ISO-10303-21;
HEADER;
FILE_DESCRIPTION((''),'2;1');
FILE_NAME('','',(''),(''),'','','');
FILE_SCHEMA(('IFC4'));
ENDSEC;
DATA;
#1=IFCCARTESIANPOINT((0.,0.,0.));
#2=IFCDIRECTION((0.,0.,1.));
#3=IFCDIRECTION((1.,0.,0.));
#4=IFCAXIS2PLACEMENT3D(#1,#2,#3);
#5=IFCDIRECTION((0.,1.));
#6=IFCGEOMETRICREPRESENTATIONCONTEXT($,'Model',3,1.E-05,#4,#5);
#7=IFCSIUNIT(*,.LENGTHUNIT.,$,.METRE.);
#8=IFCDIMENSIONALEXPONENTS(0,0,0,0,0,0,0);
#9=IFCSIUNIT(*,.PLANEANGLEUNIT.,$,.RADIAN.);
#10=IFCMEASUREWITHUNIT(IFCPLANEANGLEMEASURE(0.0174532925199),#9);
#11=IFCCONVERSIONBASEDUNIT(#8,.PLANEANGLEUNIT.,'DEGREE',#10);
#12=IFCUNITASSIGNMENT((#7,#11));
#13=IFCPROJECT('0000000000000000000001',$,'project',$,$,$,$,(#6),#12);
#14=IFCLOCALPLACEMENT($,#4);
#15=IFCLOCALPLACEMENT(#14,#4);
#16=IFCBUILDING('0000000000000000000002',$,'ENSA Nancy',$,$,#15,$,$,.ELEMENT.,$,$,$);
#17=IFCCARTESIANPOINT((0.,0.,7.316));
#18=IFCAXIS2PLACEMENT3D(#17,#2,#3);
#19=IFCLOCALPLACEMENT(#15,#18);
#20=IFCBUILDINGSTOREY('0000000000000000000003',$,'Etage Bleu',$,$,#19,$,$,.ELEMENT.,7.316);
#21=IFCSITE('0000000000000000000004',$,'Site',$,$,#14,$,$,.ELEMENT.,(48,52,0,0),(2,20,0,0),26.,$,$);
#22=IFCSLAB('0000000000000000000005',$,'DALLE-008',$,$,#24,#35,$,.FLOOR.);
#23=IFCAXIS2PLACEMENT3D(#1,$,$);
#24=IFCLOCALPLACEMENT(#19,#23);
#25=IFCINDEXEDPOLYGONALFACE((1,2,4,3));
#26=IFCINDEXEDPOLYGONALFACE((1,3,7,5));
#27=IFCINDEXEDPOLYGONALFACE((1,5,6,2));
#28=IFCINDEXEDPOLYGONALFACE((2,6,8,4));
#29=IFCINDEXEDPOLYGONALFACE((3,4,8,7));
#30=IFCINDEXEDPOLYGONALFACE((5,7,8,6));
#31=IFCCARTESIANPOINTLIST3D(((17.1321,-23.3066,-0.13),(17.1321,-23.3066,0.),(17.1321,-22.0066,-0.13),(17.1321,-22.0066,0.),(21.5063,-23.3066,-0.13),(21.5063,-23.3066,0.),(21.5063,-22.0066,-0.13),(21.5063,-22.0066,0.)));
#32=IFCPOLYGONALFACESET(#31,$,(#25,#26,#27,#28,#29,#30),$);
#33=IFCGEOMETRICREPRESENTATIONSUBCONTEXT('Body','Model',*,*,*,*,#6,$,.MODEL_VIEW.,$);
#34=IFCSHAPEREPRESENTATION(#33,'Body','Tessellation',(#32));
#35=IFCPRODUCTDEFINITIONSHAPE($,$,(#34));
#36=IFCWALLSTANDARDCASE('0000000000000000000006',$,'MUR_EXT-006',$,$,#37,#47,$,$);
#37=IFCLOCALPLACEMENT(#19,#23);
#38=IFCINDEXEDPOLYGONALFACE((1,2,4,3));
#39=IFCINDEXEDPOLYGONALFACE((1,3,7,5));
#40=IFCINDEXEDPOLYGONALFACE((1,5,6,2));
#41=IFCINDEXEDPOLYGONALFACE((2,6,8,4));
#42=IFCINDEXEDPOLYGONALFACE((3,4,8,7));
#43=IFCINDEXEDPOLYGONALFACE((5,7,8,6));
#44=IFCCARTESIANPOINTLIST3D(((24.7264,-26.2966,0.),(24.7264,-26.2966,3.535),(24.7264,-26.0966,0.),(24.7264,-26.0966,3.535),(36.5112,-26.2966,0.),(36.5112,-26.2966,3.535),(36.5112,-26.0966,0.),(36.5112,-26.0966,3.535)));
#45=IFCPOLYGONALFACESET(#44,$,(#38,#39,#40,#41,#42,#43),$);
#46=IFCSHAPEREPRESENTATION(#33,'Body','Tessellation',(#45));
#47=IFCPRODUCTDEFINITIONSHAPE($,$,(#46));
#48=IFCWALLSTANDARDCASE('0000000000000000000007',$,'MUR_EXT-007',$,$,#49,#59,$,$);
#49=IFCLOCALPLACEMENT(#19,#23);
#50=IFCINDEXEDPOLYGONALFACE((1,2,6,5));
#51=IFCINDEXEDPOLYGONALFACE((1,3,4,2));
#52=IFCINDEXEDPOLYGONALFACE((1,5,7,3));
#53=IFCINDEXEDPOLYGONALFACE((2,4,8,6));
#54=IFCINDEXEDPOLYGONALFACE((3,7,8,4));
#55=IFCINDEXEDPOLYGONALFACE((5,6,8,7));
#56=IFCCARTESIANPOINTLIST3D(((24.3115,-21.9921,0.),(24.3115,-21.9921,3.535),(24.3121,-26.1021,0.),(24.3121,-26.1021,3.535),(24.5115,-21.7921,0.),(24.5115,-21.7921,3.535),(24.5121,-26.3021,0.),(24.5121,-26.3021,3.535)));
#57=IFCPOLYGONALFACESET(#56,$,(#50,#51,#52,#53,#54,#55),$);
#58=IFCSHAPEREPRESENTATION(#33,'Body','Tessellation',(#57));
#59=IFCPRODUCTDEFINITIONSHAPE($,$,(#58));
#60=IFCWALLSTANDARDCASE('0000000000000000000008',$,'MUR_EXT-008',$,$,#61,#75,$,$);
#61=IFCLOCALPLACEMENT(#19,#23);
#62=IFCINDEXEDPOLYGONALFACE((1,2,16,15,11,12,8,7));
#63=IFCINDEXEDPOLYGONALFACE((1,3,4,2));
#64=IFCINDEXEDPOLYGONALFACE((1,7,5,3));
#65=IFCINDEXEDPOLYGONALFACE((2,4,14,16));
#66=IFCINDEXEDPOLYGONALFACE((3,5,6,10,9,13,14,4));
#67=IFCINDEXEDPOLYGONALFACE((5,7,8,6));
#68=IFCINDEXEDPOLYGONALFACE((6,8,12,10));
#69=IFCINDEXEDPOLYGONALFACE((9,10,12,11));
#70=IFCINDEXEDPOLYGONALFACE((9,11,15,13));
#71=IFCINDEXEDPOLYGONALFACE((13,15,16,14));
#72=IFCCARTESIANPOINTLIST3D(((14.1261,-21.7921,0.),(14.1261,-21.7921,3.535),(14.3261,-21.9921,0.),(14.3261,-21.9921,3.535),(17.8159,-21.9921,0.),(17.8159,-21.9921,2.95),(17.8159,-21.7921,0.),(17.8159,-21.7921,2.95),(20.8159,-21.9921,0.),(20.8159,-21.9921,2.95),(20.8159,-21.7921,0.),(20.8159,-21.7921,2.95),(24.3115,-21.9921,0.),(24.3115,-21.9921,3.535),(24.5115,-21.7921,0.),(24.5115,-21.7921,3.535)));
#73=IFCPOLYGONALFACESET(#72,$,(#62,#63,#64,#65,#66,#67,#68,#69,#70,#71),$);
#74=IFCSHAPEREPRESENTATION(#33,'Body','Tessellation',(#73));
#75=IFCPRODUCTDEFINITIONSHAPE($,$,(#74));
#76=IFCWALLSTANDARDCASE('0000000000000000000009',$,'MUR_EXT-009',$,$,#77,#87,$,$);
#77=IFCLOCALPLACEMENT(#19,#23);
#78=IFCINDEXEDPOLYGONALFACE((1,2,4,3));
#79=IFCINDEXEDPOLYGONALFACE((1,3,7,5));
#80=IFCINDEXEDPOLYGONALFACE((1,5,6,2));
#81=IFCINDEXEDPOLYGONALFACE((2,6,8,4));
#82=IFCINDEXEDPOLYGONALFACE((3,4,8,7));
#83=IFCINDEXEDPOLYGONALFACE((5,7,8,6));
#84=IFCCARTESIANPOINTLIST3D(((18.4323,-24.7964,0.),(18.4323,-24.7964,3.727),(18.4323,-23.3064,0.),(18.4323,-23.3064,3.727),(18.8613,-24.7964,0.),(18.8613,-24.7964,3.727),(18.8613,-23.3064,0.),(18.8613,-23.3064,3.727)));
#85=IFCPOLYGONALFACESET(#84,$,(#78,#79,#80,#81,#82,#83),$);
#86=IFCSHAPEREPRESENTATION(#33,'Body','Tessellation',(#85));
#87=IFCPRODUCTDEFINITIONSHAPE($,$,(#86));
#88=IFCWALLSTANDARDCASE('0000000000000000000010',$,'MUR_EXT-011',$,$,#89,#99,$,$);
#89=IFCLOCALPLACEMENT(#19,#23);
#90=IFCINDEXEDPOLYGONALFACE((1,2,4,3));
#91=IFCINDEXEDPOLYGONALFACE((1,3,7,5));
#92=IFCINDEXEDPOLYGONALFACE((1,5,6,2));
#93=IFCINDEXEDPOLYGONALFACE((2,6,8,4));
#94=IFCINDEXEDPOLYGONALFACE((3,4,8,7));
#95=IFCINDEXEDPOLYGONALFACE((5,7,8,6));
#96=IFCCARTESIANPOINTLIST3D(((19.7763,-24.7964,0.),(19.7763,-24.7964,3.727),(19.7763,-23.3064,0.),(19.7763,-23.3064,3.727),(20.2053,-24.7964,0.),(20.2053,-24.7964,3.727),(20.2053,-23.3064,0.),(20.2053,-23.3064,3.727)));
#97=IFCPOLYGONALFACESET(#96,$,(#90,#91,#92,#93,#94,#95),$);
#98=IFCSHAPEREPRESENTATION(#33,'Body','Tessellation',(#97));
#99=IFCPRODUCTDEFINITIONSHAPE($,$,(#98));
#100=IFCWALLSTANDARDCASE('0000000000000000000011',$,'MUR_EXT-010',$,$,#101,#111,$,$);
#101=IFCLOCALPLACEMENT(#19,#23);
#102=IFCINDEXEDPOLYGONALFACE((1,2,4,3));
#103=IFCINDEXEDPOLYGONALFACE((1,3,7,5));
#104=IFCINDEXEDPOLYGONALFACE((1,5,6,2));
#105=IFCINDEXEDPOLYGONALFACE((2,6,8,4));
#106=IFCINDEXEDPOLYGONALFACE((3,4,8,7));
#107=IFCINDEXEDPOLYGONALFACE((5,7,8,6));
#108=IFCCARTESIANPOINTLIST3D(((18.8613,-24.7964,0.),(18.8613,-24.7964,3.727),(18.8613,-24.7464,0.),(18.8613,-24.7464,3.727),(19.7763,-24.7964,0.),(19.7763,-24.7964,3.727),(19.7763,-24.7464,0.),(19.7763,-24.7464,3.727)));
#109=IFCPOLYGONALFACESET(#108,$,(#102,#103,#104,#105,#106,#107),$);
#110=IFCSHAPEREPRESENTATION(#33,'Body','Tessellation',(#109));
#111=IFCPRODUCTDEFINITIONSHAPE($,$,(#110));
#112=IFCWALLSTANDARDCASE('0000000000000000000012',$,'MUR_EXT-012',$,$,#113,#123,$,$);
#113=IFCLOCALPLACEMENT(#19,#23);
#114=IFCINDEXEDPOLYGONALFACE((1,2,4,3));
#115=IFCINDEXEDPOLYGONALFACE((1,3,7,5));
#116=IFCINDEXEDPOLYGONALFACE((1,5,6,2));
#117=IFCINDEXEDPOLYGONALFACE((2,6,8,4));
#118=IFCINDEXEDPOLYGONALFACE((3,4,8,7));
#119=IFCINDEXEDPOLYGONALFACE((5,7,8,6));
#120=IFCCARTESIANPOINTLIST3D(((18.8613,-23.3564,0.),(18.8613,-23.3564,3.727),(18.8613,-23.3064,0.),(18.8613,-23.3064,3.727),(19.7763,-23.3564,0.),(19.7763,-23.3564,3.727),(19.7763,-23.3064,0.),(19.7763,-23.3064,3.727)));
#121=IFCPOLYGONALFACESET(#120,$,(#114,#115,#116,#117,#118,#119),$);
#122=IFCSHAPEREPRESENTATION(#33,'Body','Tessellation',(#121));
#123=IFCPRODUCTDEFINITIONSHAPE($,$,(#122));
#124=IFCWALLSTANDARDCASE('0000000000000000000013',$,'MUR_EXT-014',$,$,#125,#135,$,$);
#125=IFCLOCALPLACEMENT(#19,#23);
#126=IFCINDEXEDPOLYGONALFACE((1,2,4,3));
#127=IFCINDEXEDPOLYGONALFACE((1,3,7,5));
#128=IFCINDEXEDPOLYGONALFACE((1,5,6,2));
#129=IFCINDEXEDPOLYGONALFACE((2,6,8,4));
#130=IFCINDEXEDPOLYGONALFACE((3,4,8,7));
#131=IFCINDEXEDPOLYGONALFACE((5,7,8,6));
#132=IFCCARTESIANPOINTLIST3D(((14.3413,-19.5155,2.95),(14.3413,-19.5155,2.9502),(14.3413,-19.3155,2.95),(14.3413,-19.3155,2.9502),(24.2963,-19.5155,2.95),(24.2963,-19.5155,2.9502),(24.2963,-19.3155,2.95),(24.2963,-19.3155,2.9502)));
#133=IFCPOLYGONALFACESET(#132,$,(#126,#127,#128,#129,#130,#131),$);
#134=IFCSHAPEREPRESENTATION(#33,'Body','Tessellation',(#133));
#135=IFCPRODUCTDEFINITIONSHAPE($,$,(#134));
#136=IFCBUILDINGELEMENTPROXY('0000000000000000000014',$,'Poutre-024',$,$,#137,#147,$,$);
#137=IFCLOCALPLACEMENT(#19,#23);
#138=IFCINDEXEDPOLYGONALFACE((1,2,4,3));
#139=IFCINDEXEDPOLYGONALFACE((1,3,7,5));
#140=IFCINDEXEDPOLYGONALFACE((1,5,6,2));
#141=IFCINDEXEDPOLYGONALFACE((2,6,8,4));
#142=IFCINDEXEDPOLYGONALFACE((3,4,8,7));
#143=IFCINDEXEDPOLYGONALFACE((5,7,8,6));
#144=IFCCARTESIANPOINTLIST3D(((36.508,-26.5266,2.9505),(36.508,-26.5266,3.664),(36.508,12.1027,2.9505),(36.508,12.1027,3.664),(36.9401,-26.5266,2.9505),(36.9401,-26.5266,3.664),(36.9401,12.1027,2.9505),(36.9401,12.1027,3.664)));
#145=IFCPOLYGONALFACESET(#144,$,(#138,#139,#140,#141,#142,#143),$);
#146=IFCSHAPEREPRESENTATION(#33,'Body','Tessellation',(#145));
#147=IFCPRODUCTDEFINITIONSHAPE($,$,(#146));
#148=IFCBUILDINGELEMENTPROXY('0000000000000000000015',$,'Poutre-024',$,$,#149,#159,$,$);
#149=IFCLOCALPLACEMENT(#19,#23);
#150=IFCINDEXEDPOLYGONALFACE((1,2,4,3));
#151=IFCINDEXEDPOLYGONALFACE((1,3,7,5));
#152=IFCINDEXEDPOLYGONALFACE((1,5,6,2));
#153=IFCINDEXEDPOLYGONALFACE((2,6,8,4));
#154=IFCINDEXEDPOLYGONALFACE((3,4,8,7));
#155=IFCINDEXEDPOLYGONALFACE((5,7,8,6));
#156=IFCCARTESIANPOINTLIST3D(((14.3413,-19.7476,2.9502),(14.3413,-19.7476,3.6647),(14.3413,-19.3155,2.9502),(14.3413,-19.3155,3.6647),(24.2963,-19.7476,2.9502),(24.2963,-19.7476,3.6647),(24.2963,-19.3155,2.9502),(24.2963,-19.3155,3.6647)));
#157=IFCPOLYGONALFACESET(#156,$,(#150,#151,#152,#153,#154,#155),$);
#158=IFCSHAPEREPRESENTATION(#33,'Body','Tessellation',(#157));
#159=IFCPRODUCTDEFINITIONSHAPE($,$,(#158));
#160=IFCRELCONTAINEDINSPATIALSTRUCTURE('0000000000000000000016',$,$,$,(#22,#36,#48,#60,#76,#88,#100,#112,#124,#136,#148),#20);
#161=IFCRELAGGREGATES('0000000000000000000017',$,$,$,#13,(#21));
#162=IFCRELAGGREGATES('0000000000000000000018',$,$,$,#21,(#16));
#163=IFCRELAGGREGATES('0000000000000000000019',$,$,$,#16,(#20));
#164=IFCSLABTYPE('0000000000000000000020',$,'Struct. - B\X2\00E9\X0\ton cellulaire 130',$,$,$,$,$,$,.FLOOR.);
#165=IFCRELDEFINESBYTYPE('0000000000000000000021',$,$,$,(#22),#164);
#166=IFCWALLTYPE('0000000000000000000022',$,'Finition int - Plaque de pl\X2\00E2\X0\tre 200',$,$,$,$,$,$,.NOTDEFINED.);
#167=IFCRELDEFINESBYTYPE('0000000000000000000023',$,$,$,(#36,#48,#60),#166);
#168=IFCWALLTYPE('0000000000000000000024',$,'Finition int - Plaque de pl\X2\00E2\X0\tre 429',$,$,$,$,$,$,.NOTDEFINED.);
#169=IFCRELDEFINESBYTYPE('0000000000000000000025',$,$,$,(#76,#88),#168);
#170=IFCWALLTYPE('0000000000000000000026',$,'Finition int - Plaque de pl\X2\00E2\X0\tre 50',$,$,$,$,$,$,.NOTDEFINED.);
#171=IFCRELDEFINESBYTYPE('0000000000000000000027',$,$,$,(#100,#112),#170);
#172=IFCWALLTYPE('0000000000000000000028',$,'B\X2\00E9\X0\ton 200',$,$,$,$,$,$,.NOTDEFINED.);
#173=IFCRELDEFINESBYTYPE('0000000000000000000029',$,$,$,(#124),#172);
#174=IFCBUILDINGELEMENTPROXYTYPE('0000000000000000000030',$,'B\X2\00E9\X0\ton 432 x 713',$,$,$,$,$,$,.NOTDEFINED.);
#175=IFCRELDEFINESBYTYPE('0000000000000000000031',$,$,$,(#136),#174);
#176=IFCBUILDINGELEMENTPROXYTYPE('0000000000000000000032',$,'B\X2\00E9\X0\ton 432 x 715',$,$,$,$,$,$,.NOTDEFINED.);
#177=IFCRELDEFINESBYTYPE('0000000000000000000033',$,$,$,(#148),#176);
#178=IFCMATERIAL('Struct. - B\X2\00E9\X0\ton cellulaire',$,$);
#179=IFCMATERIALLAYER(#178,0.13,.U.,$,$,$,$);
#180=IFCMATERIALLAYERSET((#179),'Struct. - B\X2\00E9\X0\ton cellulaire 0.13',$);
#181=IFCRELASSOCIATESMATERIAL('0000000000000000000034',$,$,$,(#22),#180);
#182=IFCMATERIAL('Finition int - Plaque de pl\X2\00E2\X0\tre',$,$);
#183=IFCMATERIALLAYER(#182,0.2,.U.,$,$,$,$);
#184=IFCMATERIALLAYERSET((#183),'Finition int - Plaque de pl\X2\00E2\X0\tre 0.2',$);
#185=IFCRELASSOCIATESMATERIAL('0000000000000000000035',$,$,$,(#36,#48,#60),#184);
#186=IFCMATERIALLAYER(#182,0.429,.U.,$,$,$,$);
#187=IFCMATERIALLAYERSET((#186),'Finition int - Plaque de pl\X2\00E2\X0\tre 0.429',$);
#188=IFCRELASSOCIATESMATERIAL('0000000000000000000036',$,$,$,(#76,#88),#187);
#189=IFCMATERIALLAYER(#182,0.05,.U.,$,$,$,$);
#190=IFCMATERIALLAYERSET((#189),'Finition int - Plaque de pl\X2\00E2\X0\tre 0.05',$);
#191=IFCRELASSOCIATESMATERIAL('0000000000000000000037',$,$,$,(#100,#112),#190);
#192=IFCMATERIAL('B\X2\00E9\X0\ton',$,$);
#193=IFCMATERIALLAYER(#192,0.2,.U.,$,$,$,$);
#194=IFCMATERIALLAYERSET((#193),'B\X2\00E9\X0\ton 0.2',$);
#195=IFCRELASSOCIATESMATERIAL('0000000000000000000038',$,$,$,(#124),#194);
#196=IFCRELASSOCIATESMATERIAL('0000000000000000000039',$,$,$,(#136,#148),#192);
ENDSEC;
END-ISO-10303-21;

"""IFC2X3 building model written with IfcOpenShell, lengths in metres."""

from ifc_helpers import new_model, entity, si_unit, converted_unit, direction, frame, frame_2d, origin_with_axes, origin_2d_with_axis, place, context, subcontext, project, spatial, polyline, rectangle, outline, extrude, material, layer, layer_set, layer_usage, type_object, element, save


model = new_model("IFC2X3")

# Units and contexts
model_context = context("Model", 3, precision=1e-05, world=origin_with_axes(), true_north=direction((0.0, 1.0)))
body_context = subcontext(model_context, "Body", "Model", "MODEL_VIEW")
ifc_project = project(units=[si_unit("LENGTHUNIT", "METRE"), converted_unit("PLANEANGLEUNIT", "DEGREE", entity("IfcPlaneAngleMeasure", 0.0174532925199), si_unit("PLANEANGLEUNIT", "RADIAN"), dimensions=[0, 0, 0, 0, 0, 0, 0])], contexts=[model_context])

# Site, building, storey
site_placement = place(None, origin_with_axes())
site = spatial("IfcSite", under=ifc_project, at=site_placement, Name="Site", CompositionType="ELEMENT", RefLatitude=(48, 52, 0, 0), RefLongitude=(2, 20, 0, 0), RefElevation=26.0)
building_placement = place(site_placement, origin_with_axes())
building = spatial("IfcBuilding", under=site, at=building_placement, Name="ENSA Nancy", CompositionType="ELEMENT")
storey_placement = place(building_placement, frame((0.0, 0.0, 7.316), z_axis=(0.0, 0.0, 1.0), x_axis=(1.0, 0.0, 0.0)))
storey = spatial("IfcBuildingStorey", under=building, at=storey_placement, Name="Etage Bleu", CompositionType="ELEMENT", Elevation=7.316)

# Slab
ifc_material_1 = material(Name="Struct. - Béton cellulaire")
ifc_layer_1 = layer(ifc_material_1, 0.13, ventilated="UNKNOWN")
ifc_layer_set_1 = layer_set([ifc_layer_1], Name="Struct. - Béton cellulaire 0.13")
ifc_layer_usage_1 = layer_usage(ifc_layer_set_1, "AXIS3", "NEGATIVE", 0.13)
slab_type = type_object("IfcSlabType", Name="Struct. - Béton cellulaire 130", PredefinedType="FLOOR")
slab_placement = place(storey_placement, frame((17.1321, -23.3066, 0.0), z_axis=(0.0, 0.0, 1.0), x_axis=(1.0, 0.0, 0.0)))
element("IfcSlab", 1, at=slab_placement, inside=storey, type_object=slab_type, material=ifc_layer_usage_1, Name="DALLE-008", PredefinedType="FLOOR", context=body_context, shape_type="SweptSolid", body=[
    extrude(outline(polyline([(0.0, 0.0), (4.3743, 0.0), (4.3743, 1.3), (0.0, 1.3), (0.0, 0.0)])), frame((0.0, 0.0, -0.13), z_axis=(0.0, 0.0, 1.0), x_axis=(1.0, 0.0, 0.0)), (0.0, 0.0, 1.0), 0.13),
])

# Walls
ifc_material_2 = material(Name="Finition int - Plaque de plâtre")
ifc_layer_2 = layer(ifc_material_2, 0.2, ventilated="UNKNOWN")
ifc_layer_set_2 = layer_set([ifc_layer_2], Name="Finition int - Plaque de plâtre 0.2")
ifc_layer_usage_2 = layer_usage(ifc_layer_set_2, "AXIS2", "NEGATIVE", 0.0)
wall_type_1 = type_object("IfcWallType", Name="Finition int - Plaque de plâtre 200", PredefinedType="NOTDEFINED")
wall_1_placement = place(storey_placement, frame((36.5112, -26.2966, 0.0), z_axis=(0.0, 0.0, 1.0), x_axis=(-1.0, 0.0, 0.0)))
element("IfcWallStandardCase", 2, at=wall_1_placement, inside=storey, type_object=wall_type_1, material=ifc_layer_usage_2, Name="MUR_EXT-006", context=body_context, shape_type="SweptSolid", body=[
    extrude(outline(polyline([(0.0, -0.2), (11.7849, -0.2), (11.7849, 0.0), (0.0, 0.0), (0.0, -0.2)])), origin_with_axes(), (0.0, 0.0, 1.0), 3.535),
])
ifc_layer_usage_3 = layer_usage(ifc_layer_set_2, "AXIS2", "POSITIVE", 0.0)
wall_2_placement = place(storey_placement, frame((24.5121, -26.3021, 0.0), z_axis=(0.0, 0.0, 1.0), x_axis=(-0.00015, 1.0, 0.0)))
element("IfcWallStandardCase", 3, at=wall_2_placement, inside=storey, type_object=wall_type_1, material=ifc_layer_usage_3, Name="MUR_EXT-007", context=body_context, shape_type="SweptSolid", body=[
    extrude(outline(polyline([(0.0, 0.0), (4.51, 0.0), (4.31, 0.2), (0.2, 0.2), (0.0, 0.0)])), origin_with_axes(), (0.0, 0.0, 1.0), 3.535),
])

# Wall, opening
ifc_layer_usage_4 = layer_usage(ifc_layer_set_2, "AXIS2", "POSITIVE", 0.0)
wall_3_placement = place(storey_placement, frame((24.5115, -21.7921, 0.0), z_axis=(0.0, 0.0, 1.0), x_axis=(-1.0, -0.000003, 0.0)))
wall_3 = element("IfcWallStandardCase", 4, at=wall_3_placement, inside=storey, type_object=wall_type_1, material=ifc_layer_usage_4, Name="MUR_EXT-008", context=body_context, shape_type="SweptSolid", body=[
    extrude(outline(polyline([(0.0, 0.0), (10.3854, 0.0), (10.1854, 0.2), (0.2, 0.2), (0.0, 0.0)])), origin_with_axes(), (0.0, 0.0, 1.0), 3.535),
])
opening_1_placement = place(wall_3_placement, frame((5.1955, 0.0, 0.0), z_axis=(0.0, 0.0, 1.0), x_axis=(1.0, 0.0, 0.0)))
element("IfcOpeningElement", 5, at=opening_1_placement, cuts=wall_3, context=body_context, shape_type="SweptSolid", body=[
    extrude(rectangle(XDim=3.0, YDim=2.95, at=origin_2d_with_axis()), frame((0.0, 0.2, 1.475), z_axis=(0.0, -1.0, 0.0), x_axis=(1.0, 0.0, 0.0)), (0.0, 0.0, 1.0), 0.6),
])

# Walls
ifc_layer_3 = layer(ifc_material_2, 0.429, ventilated="UNKNOWN")
ifc_layer_set_3 = layer_set([ifc_layer_3], Name="Finition int - Plaque de plâtre 0.429")
ifc_layer_usage_5 = layer_usage(ifc_layer_set_3, "AXIS2", "POSITIVE", -0.429)
wall_type_2 = type_object("IfcWallType", Name="Finition int - Plaque de plâtre 429", PredefinedType="NOTDEFINED")
wall_4_placement = place(storey_placement, frame((18.8613, -23.3064, 0.0), z_axis=(0.0, 0.0, 1.0), x_axis=(0.0, -1.0, 0.0)))
element("IfcWallStandardCase", 6, at=wall_4_placement, inside=storey, type_object=wall_type_2, material=ifc_layer_usage_5, Name="MUR_EXT-009", context=body_context, shape_type="SweptSolid", body=[
    extrude(outline(polyline([(0.0, -0.429), (1.49, -0.429), (1.49, 0.0), (0.0, 0.0), (0.0, -0.429)])), origin_with_axes(), (0.0, 0.0, 1.0), 3.727),
])
ifc_layer_usage_6 = layer_usage(ifc_layer_set_3, "AXIS2", "POSITIVE", -0.429)
wall_5_placement = place(storey_placement, frame((19.7763, -24.7964, 0.0), z_axis=(0.0, 0.0, 1.0), x_axis=(0.0, 1.0, 0.0)))
element("IfcWallStandardCase", 7, at=wall_5_placement, inside=storey, type_object=wall_type_2, material=ifc_layer_usage_6, Name="MUR_EXT-011", context=body_context, shape_type="SweptSolid", body=[
    extrude(outline(polyline([(0.0, -0.429), (1.49, -0.429), (1.49, 0.0), (0.0, 0.0), (0.0, -0.429)])), origin_with_axes(), (0.0, 0.0, 1.0), 3.727),
])
ifc_layer_4 = layer(ifc_material_2, 0.05, ventilated="UNKNOWN")
ifc_layer_set_4 = layer_set([ifc_layer_4], Name="Finition int - Plaque de plâtre 0.05")
ifc_layer_usage_7 = layer_usage(ifc_layer_set_4, "AXIS2", "POSITIVE", -0.05)
wall_type_3 = type_object("IfcWallType", Name="Finition int - Plaque de plâtre 50", PredefinedType="NOTDEFINED")
wall_6_placement = place(storey_placement, frame((18.8613, -24.7464, 0.0), z_axis=(0.0, 0.0, 1.0), x_axis=(1.0, 0.0, 0.0)))
element("IfcWallStandardCase", 8, at=wall_6_placement, inside=storey, type_object=wall_type_3, material=ifc_layer_usage_7, Name="MUR_EXT-010", context=body_context, shape_type="SweptSolid", body=[
    extrude(outline(polyline([(0.0, -0.05), (0.915, -0.05), (0.915, 0.0), (0.0, 0.0), (0.0, -0.05)])), origin_with_axes(), (0.0, 0.0, 1.0), 3.727),
])
ifc_layer_usage_8 = layer_usage(ifc_layer_set_4, "AXIS2", "POSITIVE", -0.05)
wall_7_placement = place(storey_placement, frame((19.7763, -23.3564, 0.0), z_axis=(0.0, 0.0, 1.0), x_axis=(-1.0, 0.0, 0.0)))
element("IfcWallStandardCase", 9, at=wall_7_placement, inside=storey, type_object=wall_type_3, material=ifc_layer_usage_8, Name="MUR_EXT-012", context=body_context, shape_type="SweptSolid", body=[
    extrude(outline(polyline([(0.0, -0.05), (0.915, -0.05), (0.915, 0.0), (0.0, 0.0), (0.0, -0.05)])), origin_with_axes(), (0.0, 0.0, 1.0), 3.727),
])

# Wall, opening
ifc_material_3 = material(Name="Béton")
ifc_layer_5 = layer(ifc_material_3, 0.2, ventilated="UNKNOWN")
ifc_layer_set_5 = layer_set([ifc_layer_5], Name="Béton 0.2")
ifc_layer_usage_9 = layer_usage(ifc_layer_set_5, "AXIS2", "POSITIVE", -0.2)
wall_type_4 = type_object("IfcWallType", Name="Béton 200", PredefinedType="NOTDEFINED")
wall_8_placement = place(storey_placement, frame((14.3413, -19.3155, 0.0), z_axis=(0.0, 0.0, 1.0), x_axis=(1.0, 0.0, 0.0)))
wall_8 = element("IfcWallStandardCase", 10, at=wall_8_placement, inside=storey, type_object=wall_type_4, material=ifc_layer_usage_9, Name="MUR_EXT-014", context=body_context, shape_type="SweptSolid", body=[
    extrude(outline(polyline([(0.0, -0.2), (9.955, -0.2), (9.955, 0.0), (0.0, 0.0), (0.0, -0.2)])), origin_with_axes(), (0.0, 0.0, 1.0), 2.9502),
])
opening_2_placement = place(wall_8_placement, frame((4.9775, 0.0, 0.0), z_axis=(0.0, 0.0, 1.0), x_axis=(1.0, 0.0, 0.0)))
element("IfcOpeningElement", 11, at=opening_2_placement, cuts=wall_8, context=body_context, shape_type="SweptSolid", body=[
    extrude(rectangle(XDim=9.955, YDim=2.95, at=origin_2d_with_axis()), frame((0.0, -0.2, 1.475), z_axis=(0.0, -1.0, 0.0), x_axis=(1.0, 0.0, 0.0)), (0.0, 0.0, -1.0), 0.6),
])

# Building element proxies
building_element_proxy_type_1 = type_object("IfcBuildingElementProxyType", Name="Béton 432 x 713", PredefinedType="NOTDEFINED")
proxy_1_placement = place(storey_placement, frame((36.724, -26.5266, 3.664), z_axis=(0.0, 0.0, 1.0), x_axis=(1.0, 0.0, 0.0)))
element("IfcBuildingElementProxy", 12, at=proxy_1_placement, inside=storey, type_object=building_element_proxy_type_1, material=ifc_material_3, Name="Poutre-024", context=body_context, shape_type="SweptSolid", body=[
    extrude(rectangle(XDim=0.7135, YDim=0.4321, at=frame_2d((-0.3567, 0.0), x_axis=(1.0, 0.0))), frame((0.0, 0.0, 0.0), z_axis=(0.0, 1.0, 0.0), x_axis=(0.0, 0.0, 1.0)), (0.0, 0.0, 1.0), 38.6293),
])
building_element_proxy_type_2 = type_object("IfcBuildingElementProxyType", Name="Béton 432 x 715", PredefinedType="NOTDEFINED")
proxy_2_placement = place(storey_placement, frame((24.2963, -19.5316, 3.6647), z_axis=(0.0, 0.0, 1.0), x_axis=(0.0, 1.0, 0.0)))
element("IfcBuildingElementProxy", 13, at=proxy_2_placement, inside=storey, type_object=building_element_proxy_type_2, material=ifc_material_3, Name="Poutre-024", context=body_context, shape_type="SweptSolid", body=[
    extrude(rectangle(XDim=0.7145, YDim=0.4321, at=frame_2d((-0.3573, 0.0), x_axis=(1.0, 0.0))), frame((0.0, 0.0, 0.0), z_axis=(0.0, 1.0, 0.0), x_axis=(0.0, 0.0, 1.0)), (0.0, 0.0, 1.0), 9.955),
])

save(model, "model.ifc")
